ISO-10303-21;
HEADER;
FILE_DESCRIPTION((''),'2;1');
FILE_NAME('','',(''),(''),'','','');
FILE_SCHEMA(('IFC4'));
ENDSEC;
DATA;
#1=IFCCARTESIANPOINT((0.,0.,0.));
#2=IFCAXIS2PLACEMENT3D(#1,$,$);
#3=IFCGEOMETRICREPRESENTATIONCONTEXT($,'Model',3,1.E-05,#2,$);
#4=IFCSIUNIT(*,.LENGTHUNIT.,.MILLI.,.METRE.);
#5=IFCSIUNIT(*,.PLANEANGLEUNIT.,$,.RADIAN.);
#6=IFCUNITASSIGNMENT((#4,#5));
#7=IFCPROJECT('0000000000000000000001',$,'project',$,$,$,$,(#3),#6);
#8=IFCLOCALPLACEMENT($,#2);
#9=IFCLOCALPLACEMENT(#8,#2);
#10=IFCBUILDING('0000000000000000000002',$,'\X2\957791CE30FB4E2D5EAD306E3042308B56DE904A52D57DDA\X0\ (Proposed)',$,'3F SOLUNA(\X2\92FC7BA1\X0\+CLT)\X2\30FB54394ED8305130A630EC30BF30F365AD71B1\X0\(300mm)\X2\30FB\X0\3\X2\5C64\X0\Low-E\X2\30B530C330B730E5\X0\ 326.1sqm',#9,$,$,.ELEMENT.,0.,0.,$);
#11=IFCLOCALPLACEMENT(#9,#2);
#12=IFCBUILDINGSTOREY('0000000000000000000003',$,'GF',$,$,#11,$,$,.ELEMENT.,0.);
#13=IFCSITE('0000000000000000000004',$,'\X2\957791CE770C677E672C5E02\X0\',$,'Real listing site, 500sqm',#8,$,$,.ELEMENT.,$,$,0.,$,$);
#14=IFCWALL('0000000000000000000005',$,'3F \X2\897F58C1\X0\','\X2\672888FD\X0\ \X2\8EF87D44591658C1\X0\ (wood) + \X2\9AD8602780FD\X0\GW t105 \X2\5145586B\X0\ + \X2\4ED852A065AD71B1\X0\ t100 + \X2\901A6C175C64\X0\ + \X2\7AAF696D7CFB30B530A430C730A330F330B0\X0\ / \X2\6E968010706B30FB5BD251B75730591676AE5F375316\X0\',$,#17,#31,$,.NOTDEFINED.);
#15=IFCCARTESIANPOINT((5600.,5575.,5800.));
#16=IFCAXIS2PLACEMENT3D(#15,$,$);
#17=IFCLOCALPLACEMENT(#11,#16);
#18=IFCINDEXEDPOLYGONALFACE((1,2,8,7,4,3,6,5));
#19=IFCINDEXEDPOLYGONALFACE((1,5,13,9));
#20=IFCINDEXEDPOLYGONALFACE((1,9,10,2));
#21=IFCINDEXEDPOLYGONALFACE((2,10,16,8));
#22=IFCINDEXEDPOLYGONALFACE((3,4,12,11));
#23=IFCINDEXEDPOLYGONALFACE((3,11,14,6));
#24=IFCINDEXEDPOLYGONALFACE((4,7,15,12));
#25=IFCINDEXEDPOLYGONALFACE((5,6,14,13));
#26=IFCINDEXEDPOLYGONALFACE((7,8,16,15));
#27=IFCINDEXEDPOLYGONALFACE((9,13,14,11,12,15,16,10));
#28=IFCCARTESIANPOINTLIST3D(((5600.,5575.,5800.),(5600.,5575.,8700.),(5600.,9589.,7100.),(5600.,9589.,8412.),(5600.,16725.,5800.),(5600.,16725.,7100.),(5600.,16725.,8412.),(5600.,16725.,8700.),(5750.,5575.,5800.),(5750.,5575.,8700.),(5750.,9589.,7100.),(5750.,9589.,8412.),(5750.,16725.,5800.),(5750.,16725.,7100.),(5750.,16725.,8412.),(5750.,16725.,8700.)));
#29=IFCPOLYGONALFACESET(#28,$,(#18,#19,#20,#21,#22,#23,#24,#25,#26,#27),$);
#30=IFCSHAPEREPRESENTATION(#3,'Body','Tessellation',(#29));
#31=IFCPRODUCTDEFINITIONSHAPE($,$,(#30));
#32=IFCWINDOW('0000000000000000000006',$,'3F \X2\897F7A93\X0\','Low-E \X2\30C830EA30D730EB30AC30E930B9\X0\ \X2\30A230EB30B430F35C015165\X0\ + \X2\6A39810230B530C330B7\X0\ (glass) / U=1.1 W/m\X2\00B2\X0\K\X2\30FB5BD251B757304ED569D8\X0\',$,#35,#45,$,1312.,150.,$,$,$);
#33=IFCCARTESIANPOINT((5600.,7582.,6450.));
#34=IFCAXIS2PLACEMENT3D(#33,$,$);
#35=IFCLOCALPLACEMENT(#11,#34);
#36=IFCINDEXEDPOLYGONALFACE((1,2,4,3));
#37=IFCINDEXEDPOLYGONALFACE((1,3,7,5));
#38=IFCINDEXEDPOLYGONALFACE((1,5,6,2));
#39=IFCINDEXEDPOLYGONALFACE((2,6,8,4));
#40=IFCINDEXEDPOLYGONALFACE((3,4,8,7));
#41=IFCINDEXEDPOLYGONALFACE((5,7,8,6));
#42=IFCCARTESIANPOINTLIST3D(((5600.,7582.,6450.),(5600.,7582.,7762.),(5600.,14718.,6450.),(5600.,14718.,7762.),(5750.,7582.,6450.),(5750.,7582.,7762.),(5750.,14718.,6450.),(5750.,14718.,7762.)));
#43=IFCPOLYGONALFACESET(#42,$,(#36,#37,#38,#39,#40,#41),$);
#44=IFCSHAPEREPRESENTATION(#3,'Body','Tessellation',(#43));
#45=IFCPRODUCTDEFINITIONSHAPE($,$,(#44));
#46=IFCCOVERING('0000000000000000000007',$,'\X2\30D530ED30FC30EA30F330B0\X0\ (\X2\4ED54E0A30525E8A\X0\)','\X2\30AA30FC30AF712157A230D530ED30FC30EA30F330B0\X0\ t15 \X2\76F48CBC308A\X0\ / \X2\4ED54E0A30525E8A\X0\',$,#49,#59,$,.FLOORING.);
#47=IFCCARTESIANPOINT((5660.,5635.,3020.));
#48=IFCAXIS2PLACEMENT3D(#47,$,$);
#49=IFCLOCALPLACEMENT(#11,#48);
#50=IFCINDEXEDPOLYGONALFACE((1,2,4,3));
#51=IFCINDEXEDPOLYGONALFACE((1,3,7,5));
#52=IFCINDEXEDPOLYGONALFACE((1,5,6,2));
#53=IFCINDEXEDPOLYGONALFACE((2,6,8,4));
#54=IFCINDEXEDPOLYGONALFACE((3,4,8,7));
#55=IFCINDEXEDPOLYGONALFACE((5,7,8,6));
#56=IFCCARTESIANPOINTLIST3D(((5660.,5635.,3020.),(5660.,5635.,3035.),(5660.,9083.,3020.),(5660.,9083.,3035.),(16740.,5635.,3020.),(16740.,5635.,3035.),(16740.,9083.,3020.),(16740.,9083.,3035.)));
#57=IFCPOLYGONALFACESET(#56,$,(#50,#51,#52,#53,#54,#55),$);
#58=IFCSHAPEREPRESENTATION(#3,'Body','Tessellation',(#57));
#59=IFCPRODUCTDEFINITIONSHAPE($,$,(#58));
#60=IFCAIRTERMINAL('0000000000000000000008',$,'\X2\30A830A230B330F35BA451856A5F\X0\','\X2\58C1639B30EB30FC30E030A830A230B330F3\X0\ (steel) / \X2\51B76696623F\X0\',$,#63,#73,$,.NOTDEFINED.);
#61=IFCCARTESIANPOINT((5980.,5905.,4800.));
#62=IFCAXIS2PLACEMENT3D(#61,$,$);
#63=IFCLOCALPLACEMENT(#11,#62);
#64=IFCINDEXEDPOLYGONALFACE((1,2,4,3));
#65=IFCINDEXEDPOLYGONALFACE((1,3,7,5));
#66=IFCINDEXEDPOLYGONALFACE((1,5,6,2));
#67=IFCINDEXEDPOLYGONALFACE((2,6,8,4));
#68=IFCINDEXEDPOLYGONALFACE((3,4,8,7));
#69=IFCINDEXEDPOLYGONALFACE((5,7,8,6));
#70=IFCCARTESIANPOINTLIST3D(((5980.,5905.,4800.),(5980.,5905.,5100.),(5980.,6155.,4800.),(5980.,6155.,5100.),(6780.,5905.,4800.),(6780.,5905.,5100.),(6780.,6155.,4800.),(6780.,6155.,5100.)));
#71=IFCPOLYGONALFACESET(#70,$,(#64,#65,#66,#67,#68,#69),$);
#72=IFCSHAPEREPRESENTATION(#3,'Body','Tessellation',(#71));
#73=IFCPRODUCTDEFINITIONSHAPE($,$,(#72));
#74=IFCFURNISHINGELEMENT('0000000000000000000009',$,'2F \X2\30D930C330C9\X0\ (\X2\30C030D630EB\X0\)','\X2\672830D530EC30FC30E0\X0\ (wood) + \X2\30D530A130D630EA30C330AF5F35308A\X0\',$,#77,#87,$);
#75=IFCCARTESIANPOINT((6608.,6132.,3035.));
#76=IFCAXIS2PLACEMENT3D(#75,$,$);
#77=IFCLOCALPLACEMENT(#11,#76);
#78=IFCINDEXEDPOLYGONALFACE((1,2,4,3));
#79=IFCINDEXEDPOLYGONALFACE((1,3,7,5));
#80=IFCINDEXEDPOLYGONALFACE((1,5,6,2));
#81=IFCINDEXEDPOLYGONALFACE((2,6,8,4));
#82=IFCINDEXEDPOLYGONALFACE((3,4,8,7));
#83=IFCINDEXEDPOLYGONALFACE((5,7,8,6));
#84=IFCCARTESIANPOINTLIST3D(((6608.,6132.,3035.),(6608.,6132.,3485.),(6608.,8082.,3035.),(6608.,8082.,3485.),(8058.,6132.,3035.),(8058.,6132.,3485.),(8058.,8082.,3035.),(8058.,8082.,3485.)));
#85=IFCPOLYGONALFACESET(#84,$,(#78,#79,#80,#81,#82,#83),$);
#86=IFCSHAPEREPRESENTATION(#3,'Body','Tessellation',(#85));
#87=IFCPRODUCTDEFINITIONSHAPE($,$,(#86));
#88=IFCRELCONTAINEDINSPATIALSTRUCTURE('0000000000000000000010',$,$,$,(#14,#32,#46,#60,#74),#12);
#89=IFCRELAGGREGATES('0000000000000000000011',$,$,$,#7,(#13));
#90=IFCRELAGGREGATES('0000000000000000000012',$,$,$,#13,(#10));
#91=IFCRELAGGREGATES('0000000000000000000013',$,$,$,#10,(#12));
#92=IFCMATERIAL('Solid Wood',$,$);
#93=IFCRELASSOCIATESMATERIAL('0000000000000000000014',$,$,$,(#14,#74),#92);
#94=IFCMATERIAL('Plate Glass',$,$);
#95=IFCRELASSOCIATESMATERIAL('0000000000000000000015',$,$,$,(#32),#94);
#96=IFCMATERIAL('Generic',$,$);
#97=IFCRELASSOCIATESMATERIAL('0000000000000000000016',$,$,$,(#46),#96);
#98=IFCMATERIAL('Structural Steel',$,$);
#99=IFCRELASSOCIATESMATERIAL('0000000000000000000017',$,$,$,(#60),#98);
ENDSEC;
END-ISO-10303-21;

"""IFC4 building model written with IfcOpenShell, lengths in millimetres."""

from ifc_helpers import new_model, si_unit, frame, frame_2d, origin, place, context, project, spatial, rectangle, extrude, material, element, fill, save


model = new_model("IFC4")

# Units and contexts
model_context = context("Model", 3, precision=1e-05, world=origin())
ifc_project = project(units=[si_unit("LENGTHUNIT", "METRE", prefix="MILLI"), si_unit("PLANEANGLEUNIT", "RADIAN")], contexts=[model_context])

# Site, building, storey
site_placement = place(None, origin())
site = spatial("IfcSite", under=ifc_project, at=site_placement, Name="長野県松本市", ObjectType="Real listing site, 500sqm", CompositionType="ELEMENT", RefElevation=0.0)
building_placement = place(site_placement, origin())
building = spatial("IfcBuilding", under=site, at=building_placement, Name="長野・中庭のある回遊動線 (Proposed)", ObjectType="3F SOLUNA(鋼管+CLT)・吹付けウレタン断熱(300mm)・3層Low-Eサッシュ 326.1sqm", CompositionType="ELEMENT", ElevationOfRefHeight=0.0, ElevationOfTerrain=0.0)
storey_placement = place(building_placement, origin())
storey = spatial("IfcBuildingStorey", under=building, at=storey_placement, Name="GF", CompositionType="ELEMENT", Elevation=0.0)

# Shared definitions
ifc_material_1 = material(Name="Solid Wood")

# Wall, opening, window
ifc_material_2 = material(Name="Plate Glass")
wall_1_placement = place(storey_placement, frame((5600.0, 5575.0, 5800.0)))
wall_1 = element("IfcWall", 1, at=wall_1_placement, inside=storey, material=ifc_material_1, Name="3F 西壁", Description="木製 軸組外壁 (wood) + 高性能GW t105 充填 + 付加断熱 t100 + 通気層 + 窯業系サイディング / 準耐火・寒冷地外皮強化", PredefinedType="NOTDEFINED", context=model_context, shape_type="SweptSolid", body=[
    extrude(rectangle(XDim=150.0, YDim=11150.0, at=frame_2d((75.0, 5575.0))), frame((5600.0, 5575.0, 5800.0)), (0.0, 0.0, 1.0), 2900.0),
])
opening_1_placement = place(storey_placement, frame((5600.0, 7582.0, 6450.0)))
opening_1 = element("IfcOpeningElement", 2, at=opening_1_placement, cuts=wall_1, PredefinedType="NOTDEFINED", context=model_context, shape_type="SweptSolid", body=[
    extrude(rectangle(XDim=150.0, YDim=7136.0, at=frame_2d((75.0, 3568.0))), frame((5600.0, 7582.0, 6450.0)), (0.0, 0.0, 1.0), 1312.0),
])
window_1_placement = place(storey_placement, frame((5600.0, 7582.0, 6450.0)))
window_1 = element("IfcWindow", 3, at=window_1_placement, inside=storey, material=ifc_material_2, Name="3F 西窓", Description="Low-E トリプルガラス アルゴン封入 + 樹脂サッシ (glass) / U=1.1 W/m²K・寒冷地仕様", OverallHeight=1312.0, OverallWidth=150.0, context=model_context, shape_type="SweptSolid", body=[
    extrude(rectangle(XDim=150.0, YDim=7136.0, at=frame_2d((75.0, 3568.0))), frame((5600.0, 7582.0, 6450.0)), (0.0, 0.0, 1.0), 1312.0),
])
fill(opening_1, window_1)

# Covering
ifc_material_3 = material(Name="Generic")
covering_placement = place(storey_placement, frame((5660.0, 5635.0, 3020.0)))
element("IfcCovering", 4, at=covering_placement, inside=storey, material=ifc_material_3, Name="フローリング (仕上げ床)", Description="オーク無垢フローリング t15 直貼り / 仕上げ床", PredefinedType="FLOORING", context=model_context, shape_type="SweptSolid", body=[
    extrude(rectangle(XDim=11080.0, YDim=3448.0, at=frame_2d((5540.0, 1724.0))), frame((5660.0, 5635.0, 3020.0)), (0.0, 0.0, 1.0), 15.0),
])

# Air terminal
ifc_material_4 = material(Name="Structural Steel")
air_terminal_placement = place(storey_placement, frame((5980.0, 5905.0, 4800.0)))
element("IfcAirTerminal", 5, at=air_terminal_placement, inside=storey, material=ifc_material_4, Name="エアコン室内機", Description="壁掛ルームエアコン (steel) / 冷暖房", PredefinedType="NOTDEFINED", context=model_context, shape_type="SweptSolid", body=[
    extrude(rectangle(XDim=800.0, YDim=250.0, at=frame_2d((400.0, 125.0))), frame((5980.0, 5905.0, 4800.0)), (0.0, 0.0, 1.0), 300.0),
])

# Furnishing element
furnishing_placement = place(storey_placement, frame((6608.0, 6132.0, 3035.0)))
element("IfcFurnishingElement", 6, at=furnishing_placement, inside=storey, material=ifc_material_1, Name="2F ベッド (ダブル)", Description="木フレーム (wood) + ファブリック張り", context=model_context, shape_type="SweptSolid", body=[
    extrude(rectangle(XDim=1450.0, YDim=1950.0, at=frame_2d((725.0, 975.0))), frame((6608.0, 6132.0, 3035.0)), (0.0, 0.0, 1.0), 450.0),
])

save(model, "model.ifc")
